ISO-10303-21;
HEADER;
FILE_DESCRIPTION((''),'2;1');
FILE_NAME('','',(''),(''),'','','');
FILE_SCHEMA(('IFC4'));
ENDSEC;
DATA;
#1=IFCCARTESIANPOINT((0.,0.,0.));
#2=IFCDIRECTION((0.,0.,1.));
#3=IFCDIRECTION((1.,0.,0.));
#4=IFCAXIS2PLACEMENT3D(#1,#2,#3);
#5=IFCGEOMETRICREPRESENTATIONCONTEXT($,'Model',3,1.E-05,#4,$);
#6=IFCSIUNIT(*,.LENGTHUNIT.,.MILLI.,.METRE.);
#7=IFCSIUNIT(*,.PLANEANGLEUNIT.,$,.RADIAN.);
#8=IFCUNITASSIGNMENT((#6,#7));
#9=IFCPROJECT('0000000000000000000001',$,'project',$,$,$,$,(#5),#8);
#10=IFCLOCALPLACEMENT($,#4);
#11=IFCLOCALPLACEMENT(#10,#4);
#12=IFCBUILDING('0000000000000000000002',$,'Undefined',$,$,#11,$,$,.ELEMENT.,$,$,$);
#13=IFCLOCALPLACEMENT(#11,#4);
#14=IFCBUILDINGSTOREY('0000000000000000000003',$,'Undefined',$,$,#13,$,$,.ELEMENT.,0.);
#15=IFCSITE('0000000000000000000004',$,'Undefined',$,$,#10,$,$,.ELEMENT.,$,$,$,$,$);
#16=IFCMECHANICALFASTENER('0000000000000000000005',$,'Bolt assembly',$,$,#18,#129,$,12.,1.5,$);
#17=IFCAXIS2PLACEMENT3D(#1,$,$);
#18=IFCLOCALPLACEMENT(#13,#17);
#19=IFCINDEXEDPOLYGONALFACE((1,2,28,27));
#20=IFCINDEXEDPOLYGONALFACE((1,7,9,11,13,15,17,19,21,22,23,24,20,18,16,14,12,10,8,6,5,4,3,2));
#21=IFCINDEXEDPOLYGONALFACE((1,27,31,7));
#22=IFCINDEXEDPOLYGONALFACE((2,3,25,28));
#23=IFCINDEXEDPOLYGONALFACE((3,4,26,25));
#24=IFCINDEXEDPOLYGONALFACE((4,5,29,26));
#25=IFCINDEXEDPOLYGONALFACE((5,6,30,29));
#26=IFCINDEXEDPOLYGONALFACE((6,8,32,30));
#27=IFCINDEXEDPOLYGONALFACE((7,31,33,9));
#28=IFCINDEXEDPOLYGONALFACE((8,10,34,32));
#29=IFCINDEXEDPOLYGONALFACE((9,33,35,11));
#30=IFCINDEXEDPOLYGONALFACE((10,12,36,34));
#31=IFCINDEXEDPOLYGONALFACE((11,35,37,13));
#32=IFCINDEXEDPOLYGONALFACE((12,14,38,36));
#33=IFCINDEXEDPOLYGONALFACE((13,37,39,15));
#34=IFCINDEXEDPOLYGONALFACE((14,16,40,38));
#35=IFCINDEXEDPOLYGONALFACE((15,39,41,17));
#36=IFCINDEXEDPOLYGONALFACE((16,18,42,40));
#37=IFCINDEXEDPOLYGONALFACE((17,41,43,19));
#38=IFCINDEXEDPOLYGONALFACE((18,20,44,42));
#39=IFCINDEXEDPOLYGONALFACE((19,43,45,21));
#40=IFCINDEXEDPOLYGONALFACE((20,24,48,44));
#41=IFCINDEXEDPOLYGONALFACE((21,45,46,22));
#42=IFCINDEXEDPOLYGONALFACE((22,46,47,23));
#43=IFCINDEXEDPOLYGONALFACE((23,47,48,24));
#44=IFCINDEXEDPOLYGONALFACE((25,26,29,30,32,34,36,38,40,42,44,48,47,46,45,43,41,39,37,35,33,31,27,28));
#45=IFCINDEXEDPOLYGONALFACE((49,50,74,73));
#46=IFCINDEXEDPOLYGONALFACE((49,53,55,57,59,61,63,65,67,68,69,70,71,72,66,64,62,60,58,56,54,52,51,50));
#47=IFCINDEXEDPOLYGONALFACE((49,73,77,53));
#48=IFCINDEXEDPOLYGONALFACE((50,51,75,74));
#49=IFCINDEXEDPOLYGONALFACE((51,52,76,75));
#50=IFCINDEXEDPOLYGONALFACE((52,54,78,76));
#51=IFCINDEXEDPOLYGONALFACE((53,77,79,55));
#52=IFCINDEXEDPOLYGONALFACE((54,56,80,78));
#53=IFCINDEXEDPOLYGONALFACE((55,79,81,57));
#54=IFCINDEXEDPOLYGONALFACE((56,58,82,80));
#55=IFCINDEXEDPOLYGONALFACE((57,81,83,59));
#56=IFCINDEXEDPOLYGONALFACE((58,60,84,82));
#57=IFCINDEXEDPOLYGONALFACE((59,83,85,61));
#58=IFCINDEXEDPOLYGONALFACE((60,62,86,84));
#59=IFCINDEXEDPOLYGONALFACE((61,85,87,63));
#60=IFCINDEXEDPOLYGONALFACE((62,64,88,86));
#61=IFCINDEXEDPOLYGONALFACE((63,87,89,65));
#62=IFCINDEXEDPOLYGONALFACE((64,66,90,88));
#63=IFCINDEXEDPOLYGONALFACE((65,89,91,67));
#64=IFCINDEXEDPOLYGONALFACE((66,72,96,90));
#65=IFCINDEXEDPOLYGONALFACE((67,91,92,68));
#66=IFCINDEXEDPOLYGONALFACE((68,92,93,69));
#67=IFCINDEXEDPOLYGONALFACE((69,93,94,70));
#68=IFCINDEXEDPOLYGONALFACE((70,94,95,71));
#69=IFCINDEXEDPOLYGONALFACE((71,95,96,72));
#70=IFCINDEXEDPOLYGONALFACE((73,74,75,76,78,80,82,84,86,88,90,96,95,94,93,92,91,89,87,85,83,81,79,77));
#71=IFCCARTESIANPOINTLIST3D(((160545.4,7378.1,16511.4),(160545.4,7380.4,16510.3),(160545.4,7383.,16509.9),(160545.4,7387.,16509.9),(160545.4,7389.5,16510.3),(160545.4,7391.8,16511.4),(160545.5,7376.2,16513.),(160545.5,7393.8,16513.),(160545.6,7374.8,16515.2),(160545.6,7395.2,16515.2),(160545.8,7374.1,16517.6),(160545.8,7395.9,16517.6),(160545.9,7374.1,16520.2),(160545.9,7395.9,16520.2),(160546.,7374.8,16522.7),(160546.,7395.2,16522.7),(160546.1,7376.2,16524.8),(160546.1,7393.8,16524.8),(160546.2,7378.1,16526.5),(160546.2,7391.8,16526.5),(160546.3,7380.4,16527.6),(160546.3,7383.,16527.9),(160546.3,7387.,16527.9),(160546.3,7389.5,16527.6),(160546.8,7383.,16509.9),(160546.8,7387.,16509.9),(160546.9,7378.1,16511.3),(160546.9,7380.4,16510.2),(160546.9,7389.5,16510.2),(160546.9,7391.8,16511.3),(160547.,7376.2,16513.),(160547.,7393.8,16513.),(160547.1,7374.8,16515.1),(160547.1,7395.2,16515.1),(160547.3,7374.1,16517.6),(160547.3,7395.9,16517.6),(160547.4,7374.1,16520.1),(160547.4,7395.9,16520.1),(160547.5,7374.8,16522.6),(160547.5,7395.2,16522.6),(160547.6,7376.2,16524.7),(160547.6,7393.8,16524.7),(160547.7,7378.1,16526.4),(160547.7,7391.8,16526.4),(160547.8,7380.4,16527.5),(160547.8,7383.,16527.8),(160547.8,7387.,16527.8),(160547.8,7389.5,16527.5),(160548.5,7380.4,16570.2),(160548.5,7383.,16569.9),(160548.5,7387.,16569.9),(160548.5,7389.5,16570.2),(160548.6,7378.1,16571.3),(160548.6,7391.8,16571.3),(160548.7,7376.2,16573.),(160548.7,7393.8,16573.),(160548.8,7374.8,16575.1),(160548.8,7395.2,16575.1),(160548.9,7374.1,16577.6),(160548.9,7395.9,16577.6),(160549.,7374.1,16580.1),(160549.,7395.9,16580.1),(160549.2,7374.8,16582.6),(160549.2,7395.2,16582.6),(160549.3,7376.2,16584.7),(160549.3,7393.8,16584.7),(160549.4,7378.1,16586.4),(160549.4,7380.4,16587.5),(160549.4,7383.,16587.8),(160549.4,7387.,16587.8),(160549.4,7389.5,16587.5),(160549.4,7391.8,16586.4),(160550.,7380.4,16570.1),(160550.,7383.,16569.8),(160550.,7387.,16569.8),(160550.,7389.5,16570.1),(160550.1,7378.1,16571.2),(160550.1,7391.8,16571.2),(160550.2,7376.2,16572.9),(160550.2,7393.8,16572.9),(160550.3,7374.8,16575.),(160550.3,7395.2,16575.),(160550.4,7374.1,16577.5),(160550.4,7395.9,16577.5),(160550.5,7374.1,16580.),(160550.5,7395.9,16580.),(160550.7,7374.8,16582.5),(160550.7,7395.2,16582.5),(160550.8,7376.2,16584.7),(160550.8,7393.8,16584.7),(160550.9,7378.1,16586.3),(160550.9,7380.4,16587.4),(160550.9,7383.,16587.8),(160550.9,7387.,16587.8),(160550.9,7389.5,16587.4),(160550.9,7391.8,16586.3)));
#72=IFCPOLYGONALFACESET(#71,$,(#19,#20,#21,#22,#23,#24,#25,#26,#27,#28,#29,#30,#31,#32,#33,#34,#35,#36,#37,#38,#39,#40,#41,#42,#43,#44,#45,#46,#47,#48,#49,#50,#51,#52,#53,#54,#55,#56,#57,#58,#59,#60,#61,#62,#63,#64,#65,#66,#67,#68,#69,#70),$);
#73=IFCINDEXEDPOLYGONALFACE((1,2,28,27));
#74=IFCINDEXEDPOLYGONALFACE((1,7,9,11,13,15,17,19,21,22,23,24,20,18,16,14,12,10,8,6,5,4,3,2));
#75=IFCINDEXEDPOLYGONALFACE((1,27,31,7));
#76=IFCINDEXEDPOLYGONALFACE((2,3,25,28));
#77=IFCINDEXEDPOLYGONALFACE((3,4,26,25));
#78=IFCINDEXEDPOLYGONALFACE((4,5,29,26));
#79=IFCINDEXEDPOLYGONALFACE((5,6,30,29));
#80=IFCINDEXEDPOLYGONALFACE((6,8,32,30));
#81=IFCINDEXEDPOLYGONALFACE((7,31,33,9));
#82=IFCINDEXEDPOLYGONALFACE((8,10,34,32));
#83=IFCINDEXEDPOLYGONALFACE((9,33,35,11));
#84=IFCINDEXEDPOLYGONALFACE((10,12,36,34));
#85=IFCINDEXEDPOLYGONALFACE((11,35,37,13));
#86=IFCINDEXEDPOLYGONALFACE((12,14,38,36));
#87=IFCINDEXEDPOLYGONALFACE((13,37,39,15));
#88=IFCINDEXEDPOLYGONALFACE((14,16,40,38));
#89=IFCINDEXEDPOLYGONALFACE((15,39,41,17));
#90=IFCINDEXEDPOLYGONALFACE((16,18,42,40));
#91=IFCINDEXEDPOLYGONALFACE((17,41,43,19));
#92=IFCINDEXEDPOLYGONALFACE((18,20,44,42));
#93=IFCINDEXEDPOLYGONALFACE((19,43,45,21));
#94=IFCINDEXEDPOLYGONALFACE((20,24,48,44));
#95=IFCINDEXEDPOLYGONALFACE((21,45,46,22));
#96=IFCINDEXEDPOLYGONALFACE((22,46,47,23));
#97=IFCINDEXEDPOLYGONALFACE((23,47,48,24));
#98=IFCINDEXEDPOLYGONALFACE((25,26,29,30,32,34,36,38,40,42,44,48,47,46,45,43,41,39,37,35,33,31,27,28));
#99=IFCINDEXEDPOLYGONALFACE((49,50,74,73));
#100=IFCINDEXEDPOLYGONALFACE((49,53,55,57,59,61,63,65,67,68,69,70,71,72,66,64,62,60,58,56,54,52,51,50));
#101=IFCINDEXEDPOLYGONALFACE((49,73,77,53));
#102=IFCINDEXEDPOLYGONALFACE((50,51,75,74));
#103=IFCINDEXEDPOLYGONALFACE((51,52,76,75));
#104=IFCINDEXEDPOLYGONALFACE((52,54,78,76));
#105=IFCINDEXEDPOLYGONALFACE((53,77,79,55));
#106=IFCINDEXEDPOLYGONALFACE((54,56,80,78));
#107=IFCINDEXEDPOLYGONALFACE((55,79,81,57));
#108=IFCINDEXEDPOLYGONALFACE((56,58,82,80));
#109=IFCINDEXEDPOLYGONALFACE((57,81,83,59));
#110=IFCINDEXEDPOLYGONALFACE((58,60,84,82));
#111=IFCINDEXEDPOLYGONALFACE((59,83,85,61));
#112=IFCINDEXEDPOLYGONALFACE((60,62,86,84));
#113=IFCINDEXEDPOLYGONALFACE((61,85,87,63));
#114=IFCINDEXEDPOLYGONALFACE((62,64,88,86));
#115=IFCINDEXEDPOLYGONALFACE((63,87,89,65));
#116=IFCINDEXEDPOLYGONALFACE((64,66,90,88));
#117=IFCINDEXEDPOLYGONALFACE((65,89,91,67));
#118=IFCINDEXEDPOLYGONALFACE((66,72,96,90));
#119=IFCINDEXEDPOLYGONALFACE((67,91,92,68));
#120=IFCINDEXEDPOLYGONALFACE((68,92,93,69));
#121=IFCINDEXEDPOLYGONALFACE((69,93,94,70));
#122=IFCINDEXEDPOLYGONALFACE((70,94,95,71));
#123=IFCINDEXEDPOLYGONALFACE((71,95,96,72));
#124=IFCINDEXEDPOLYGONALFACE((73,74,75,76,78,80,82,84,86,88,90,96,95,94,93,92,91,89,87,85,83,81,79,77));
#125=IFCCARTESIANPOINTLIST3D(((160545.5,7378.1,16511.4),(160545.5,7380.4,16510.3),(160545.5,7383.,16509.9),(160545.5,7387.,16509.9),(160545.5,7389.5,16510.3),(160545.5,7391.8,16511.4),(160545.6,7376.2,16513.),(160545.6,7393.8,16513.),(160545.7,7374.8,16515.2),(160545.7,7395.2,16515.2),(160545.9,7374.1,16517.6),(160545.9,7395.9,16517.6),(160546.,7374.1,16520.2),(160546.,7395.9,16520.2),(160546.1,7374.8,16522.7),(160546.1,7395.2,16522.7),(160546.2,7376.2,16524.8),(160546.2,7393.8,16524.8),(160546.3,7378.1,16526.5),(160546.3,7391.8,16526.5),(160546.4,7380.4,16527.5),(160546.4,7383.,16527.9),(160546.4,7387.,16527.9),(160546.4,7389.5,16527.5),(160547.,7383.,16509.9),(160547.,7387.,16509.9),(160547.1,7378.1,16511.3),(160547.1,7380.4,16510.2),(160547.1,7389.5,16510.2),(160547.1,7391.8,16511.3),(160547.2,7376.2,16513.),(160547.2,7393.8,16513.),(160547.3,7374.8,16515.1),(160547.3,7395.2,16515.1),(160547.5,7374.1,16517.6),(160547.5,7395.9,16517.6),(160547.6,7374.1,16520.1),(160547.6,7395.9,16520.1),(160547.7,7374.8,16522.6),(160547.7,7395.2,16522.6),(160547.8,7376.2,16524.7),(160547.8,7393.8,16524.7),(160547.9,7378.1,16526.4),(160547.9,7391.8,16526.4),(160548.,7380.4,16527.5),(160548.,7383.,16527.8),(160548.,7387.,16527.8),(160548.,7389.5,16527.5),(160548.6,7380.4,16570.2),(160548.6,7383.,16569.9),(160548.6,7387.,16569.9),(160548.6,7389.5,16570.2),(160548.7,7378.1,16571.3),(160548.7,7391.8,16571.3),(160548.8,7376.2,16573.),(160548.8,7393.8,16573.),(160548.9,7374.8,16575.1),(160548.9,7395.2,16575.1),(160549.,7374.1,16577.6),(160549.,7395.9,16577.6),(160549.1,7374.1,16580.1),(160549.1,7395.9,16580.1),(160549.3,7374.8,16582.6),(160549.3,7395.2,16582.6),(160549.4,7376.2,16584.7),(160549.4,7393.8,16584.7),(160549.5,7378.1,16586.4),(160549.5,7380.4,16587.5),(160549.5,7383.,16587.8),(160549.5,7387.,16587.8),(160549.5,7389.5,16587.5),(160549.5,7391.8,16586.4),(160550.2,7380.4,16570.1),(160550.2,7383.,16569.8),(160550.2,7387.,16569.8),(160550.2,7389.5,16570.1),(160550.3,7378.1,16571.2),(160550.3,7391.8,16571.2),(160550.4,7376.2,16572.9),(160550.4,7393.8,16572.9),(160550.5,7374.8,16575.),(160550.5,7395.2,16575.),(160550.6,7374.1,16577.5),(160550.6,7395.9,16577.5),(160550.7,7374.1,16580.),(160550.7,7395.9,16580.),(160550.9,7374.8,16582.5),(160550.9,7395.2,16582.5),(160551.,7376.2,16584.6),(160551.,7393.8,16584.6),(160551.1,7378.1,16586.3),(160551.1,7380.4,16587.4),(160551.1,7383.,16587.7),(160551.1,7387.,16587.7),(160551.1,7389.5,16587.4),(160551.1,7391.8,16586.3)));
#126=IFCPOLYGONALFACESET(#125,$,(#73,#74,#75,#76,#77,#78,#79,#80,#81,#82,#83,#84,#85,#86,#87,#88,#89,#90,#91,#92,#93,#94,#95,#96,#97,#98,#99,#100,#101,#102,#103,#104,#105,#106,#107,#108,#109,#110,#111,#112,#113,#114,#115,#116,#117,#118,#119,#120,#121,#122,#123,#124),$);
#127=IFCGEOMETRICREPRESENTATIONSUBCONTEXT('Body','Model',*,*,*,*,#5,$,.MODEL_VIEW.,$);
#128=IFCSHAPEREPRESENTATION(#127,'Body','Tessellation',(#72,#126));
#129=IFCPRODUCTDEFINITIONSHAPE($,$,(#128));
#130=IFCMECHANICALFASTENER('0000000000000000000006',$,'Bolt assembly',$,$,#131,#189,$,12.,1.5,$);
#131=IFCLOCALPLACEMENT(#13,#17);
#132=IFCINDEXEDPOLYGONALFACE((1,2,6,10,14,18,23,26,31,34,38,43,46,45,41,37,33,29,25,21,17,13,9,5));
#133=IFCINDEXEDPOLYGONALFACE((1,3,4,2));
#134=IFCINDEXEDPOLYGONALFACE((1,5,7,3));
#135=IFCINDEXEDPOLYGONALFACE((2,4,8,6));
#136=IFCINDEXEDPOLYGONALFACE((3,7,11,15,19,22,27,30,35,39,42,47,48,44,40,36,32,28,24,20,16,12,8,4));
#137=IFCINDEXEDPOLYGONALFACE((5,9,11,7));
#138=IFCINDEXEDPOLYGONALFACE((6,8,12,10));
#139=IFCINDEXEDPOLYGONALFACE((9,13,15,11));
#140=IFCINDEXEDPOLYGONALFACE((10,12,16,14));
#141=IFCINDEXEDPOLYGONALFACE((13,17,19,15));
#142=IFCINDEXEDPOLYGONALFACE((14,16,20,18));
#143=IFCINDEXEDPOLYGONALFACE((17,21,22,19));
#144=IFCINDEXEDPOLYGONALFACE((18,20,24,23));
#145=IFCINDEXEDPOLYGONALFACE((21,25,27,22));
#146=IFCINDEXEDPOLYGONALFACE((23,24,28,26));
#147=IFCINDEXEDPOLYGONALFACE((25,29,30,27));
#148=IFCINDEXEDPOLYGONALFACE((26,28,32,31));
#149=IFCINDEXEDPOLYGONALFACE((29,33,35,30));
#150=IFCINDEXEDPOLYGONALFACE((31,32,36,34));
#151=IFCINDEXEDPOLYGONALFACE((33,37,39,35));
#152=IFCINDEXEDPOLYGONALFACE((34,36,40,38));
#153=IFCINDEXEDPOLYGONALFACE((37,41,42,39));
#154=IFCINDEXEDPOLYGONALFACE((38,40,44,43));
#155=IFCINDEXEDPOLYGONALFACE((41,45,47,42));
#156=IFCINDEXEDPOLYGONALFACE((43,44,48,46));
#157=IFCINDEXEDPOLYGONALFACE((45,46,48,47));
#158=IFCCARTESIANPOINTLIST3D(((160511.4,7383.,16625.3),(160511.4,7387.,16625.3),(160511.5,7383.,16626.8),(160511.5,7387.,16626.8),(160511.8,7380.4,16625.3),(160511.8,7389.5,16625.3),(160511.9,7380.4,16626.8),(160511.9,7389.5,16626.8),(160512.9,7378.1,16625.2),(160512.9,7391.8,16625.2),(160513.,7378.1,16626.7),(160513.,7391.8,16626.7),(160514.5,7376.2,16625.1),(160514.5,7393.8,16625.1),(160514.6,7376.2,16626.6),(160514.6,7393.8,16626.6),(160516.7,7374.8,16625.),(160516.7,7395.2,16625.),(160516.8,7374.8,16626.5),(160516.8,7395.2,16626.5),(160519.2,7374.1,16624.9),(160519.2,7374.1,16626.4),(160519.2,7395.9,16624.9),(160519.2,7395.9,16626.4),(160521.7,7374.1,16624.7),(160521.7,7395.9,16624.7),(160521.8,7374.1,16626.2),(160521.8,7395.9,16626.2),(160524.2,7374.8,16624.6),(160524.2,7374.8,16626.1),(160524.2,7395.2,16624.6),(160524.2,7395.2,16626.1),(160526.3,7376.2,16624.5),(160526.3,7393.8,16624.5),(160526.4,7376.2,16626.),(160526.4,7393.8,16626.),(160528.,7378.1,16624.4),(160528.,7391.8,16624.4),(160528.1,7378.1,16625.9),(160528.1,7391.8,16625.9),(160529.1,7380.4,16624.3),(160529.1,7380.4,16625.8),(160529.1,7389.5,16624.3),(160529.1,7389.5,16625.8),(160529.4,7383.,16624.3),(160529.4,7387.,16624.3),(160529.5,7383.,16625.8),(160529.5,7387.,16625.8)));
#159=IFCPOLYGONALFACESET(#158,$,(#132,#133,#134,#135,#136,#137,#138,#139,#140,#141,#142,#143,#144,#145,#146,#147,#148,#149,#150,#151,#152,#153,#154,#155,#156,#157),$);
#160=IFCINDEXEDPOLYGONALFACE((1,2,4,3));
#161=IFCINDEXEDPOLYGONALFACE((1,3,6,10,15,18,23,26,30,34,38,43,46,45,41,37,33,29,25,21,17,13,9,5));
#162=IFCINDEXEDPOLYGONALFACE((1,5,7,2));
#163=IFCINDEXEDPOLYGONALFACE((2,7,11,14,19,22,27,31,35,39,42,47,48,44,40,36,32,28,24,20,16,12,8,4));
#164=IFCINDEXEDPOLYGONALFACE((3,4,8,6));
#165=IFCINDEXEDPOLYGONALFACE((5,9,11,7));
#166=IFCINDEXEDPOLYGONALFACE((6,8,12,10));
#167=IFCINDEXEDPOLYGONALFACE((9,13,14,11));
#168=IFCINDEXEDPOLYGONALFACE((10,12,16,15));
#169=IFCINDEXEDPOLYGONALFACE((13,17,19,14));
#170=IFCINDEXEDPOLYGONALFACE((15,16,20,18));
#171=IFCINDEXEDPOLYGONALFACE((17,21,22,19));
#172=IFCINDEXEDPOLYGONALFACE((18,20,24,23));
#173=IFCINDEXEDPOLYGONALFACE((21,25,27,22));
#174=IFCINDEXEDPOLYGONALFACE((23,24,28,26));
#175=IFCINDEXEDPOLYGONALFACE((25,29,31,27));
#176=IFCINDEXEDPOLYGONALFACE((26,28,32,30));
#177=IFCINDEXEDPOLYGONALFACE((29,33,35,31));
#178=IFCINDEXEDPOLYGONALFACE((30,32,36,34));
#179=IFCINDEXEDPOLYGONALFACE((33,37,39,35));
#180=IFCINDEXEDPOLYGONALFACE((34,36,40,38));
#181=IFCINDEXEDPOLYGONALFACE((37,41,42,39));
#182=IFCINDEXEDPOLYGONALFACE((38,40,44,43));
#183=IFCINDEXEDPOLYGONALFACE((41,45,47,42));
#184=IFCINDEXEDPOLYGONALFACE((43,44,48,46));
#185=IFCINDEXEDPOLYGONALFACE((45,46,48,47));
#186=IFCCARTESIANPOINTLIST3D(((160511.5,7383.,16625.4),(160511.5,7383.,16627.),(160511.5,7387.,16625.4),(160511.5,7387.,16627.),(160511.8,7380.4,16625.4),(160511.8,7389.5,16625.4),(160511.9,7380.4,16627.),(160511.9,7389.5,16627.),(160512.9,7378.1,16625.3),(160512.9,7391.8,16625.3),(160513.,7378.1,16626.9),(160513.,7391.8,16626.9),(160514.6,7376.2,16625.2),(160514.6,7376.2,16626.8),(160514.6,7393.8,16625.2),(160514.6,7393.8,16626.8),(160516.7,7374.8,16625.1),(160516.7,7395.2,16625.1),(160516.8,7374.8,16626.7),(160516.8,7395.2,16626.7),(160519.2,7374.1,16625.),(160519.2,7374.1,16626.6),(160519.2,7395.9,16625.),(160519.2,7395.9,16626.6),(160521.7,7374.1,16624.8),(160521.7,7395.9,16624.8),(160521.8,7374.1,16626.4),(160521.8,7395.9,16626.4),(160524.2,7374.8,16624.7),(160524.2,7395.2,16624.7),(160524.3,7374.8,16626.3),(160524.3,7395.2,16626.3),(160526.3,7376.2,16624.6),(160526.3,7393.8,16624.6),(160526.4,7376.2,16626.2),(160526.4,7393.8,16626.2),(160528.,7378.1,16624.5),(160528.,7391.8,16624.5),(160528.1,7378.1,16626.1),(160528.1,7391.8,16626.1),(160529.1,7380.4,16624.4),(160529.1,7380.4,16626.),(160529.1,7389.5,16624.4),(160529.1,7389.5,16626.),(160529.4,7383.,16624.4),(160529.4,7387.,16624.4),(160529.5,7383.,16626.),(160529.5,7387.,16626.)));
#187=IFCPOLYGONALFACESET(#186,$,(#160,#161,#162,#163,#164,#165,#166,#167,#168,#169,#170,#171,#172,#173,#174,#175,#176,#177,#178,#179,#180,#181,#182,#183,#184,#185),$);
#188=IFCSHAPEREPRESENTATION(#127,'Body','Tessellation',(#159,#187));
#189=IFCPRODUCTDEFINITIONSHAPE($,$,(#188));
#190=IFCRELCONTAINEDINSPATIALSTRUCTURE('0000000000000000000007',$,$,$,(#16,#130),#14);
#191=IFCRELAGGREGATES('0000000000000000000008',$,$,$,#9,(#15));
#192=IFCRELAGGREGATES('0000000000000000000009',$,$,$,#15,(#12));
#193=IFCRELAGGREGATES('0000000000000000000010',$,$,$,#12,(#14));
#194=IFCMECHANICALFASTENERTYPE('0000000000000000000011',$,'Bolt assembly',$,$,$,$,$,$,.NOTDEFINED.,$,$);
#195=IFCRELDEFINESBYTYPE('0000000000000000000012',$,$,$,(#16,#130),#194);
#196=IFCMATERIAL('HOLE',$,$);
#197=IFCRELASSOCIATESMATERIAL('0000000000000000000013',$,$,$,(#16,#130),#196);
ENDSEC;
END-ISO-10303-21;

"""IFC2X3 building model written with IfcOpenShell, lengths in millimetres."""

from ifc_helpers import new_model, entity, si_unit, frame, origin_with_axes, place, context, subcontext, project, spatial, source, transform, mapped, material, type_object, element, save


model = new_model("IFC2X3")

# Units and contexts
model_context = context("Model", 3, precision=1e-05, world=origin_with_axes())
body_context = subcontext(model_context, "Body", "Model", "MODEL_VIEW")
ifc_project = project(units=[si_unit("LENGTHUNIT", "METRE", prefix="MILLI"), si_unit("PLANEANGLEUNIT", "RADIAN")], contexts=[model_context])

# Site, building, storey
site_placement = place(None, origin_with_axes())
site = spatial("IfcSite", under=ifc_project, at=site_placement, Name="Undefined", CompositionType="ELEMENT")
building_placement = place(site_placement, origin_with_axes())
building = spatial("IfcBuilding", under=site, at=building_placement, Name="Undefined", CompositionType="ELEMENT")
storey_placement = place(building_placement, origin_with_axes())
storey = spatial("IfcBuildingStorey", under=building, at=storey_placement, Name="Undefined", CompositionType="ELEMENT", Elevation=0.0)

# Mechanical fasteners
ifc_material_1 = material(Name="HOLE")
mechanical_fastener_type = type_object("IfcMechanicalFastenerType", Name="Bolt assembly")
shared_circle_1 = entity("IfcCircle", entity("IfcAxis2Placement2D", entity("IfcCartesianPoint", [0.0, -2.0]), entity("IfcDirection", [1.0, 0.0])), 9.0)
shared_circle_2 = entity("IfcCircle", entity("IfcAxis2Placement2D", entity("IfcCartesianPoint", [0.0, 2.0]), entity("IfcDirection", [-1.0, 0.0])), 9.0)
shared_composite_curve = entity("IfcCompositeCurve", [entity("IfcCompositeCurveSegment", "CONTINUOUS", True, entity("IfcPolyline", [entity("IfcCartesianPoint", [9.0, 2.0]), entity("IfcCartesianPoint", [9.0, -2.0])])), entity("IfcCompositeCurveSegment", "CONTINUOUS", True, entity("IfcTrimmedCurve", shared_circle_1, [entity("IfcParameterValue", 0.0)], [entity("IfcParameterValue", 3.141593)], False, "PARAMETER")), entity("IfcCompositeCurveSegment", "CONTINUOUS", True, entity("IfcPolyline", [entity("IfcCartesianPoint", [-9.0, -2.0]), entity("IfcCartesianPoint", [-9.0, 2.0])])), entity("IfcCompositeCurveSegment", "DISCONTINUOUS", True, entity("IfcTrimmedCurve", shared_circle_2, [entity("IfcParameterValue", 0.0)], [entity("IfcParameterValue", 3.141593)], False, "PARAMETER"))], False)
shared_shape_1 = source(origin_with_axes(), body_context, "Body", "SweptSolid", [
    entity("IfcExtrudedAreaSolid", entity("IfcArbitraryClosedProfileDef", "AREA", None, shared_composite_curve), entity("IfcAxis2Placement3D", entity("IfcCartesianPoint", [0.0, 0.1, 0.0]), entity("IfcDirection", [0.0, 1.0, 0.0]), entity("IfcDirection", [1.0, 0.0, 0.0])), entity("IfcDirection", [0.0, 0.0, 1.0]), 1.5),
    entity("IfcExtrudedAreaSolid", entity("IfcArbitraryClosedProfileDef", "AREA", None, shared_composite_curve), entity("IfcAxis2Placement3D", entity("IfcCartesianPoint", [0.0, -0.1, 0.0]), entity("IfcDirection", [0.0, 1.0, 0.0]), entity("IfcDirection", [1.0, 0.0, 0.0])), entity("IfcDirection", [0.0, 0.0, 1.0]), 1.6),
])
mechanical_fastener_1_placement = place(storey_placement, frame((160550.6, 7385.0, 16578.8), z_axis=(0.0, 1.0, 0.0), x_axis=(-0.052392, 0.0, -0.998627)))
element("IfcMechanicalFastener", 1, at=mechanical_fastener_1_placement, inside=storey, type_object=mechanical_fastener_type, material=ifc_material_1, Name="Bolt assembly", NominalDiameter=12.0, NominalLength=1.5, context=body_context, shape_type="MappedRepresentation", body=[
    mapped(shared_shape_1, transform((0.0, 0.0, 0.0))),
    mapped(shared_shape_1, transform((60.0, 0.0, 0.0))),
])
shared_shape_2 = source(origin_with_axes(), body_context, "Body", "SweptSolid", [
    entity("IfcExtrudedAreaSolid", entity("IfcArbitraryClosedProfileDef", "AREA", None, shared_composite_curve), entity("IfcAxis2Placement3D", entity("IfcCartesianPoint", [0.0, -0.9, 0.0]), entity("IfcDirection", [0.0, 1.0, 0.0]), entity("IfcDirection", [1.0, 0.0, 0.0])), entity("IfcDirection", [0.0, 0.0, 1.0]), 1.5),
    entity("IfcExtrudedAreaSolid", entity("IfcArbitraryClosedProfileDef", "AREA", None, shared_composite_curve), entity("IfcAxis2Placement3D", entity("IfcCartesianPoint", [0.0, -1.1, 0.0]), entity("IfcDirection", [0.0, 1.0, 0.0]), entity("IfcDirection", [1.0, 0.0, 0.0])), entity("IfcDirection", [0.0, 0.0, 1.0]), 1.6),
])
mechanical_fastener_2_placement = place(storey_placement, frame((160520.5, 7385.0, 16625.4), z_axis=(0.0, 1.0, 0.0), x_axis=(0.998627, 0.0, -0.052392)))
element("IfcMechanicalFastener", 2, at=mechanical_fastener_2_placement, inside=storey, type_object=mechanical_fastener_type, material=ifc_material_1, Name="Bolt assembly", NominalDiameter=12.0, NominalLength=1.5, context=body_context, shape_type="MappedRepresentation", body=[
    mapped(shared_shape_2, transform((0.0, 0.0, 0.0))),
])

save(model, "model.ifc")
